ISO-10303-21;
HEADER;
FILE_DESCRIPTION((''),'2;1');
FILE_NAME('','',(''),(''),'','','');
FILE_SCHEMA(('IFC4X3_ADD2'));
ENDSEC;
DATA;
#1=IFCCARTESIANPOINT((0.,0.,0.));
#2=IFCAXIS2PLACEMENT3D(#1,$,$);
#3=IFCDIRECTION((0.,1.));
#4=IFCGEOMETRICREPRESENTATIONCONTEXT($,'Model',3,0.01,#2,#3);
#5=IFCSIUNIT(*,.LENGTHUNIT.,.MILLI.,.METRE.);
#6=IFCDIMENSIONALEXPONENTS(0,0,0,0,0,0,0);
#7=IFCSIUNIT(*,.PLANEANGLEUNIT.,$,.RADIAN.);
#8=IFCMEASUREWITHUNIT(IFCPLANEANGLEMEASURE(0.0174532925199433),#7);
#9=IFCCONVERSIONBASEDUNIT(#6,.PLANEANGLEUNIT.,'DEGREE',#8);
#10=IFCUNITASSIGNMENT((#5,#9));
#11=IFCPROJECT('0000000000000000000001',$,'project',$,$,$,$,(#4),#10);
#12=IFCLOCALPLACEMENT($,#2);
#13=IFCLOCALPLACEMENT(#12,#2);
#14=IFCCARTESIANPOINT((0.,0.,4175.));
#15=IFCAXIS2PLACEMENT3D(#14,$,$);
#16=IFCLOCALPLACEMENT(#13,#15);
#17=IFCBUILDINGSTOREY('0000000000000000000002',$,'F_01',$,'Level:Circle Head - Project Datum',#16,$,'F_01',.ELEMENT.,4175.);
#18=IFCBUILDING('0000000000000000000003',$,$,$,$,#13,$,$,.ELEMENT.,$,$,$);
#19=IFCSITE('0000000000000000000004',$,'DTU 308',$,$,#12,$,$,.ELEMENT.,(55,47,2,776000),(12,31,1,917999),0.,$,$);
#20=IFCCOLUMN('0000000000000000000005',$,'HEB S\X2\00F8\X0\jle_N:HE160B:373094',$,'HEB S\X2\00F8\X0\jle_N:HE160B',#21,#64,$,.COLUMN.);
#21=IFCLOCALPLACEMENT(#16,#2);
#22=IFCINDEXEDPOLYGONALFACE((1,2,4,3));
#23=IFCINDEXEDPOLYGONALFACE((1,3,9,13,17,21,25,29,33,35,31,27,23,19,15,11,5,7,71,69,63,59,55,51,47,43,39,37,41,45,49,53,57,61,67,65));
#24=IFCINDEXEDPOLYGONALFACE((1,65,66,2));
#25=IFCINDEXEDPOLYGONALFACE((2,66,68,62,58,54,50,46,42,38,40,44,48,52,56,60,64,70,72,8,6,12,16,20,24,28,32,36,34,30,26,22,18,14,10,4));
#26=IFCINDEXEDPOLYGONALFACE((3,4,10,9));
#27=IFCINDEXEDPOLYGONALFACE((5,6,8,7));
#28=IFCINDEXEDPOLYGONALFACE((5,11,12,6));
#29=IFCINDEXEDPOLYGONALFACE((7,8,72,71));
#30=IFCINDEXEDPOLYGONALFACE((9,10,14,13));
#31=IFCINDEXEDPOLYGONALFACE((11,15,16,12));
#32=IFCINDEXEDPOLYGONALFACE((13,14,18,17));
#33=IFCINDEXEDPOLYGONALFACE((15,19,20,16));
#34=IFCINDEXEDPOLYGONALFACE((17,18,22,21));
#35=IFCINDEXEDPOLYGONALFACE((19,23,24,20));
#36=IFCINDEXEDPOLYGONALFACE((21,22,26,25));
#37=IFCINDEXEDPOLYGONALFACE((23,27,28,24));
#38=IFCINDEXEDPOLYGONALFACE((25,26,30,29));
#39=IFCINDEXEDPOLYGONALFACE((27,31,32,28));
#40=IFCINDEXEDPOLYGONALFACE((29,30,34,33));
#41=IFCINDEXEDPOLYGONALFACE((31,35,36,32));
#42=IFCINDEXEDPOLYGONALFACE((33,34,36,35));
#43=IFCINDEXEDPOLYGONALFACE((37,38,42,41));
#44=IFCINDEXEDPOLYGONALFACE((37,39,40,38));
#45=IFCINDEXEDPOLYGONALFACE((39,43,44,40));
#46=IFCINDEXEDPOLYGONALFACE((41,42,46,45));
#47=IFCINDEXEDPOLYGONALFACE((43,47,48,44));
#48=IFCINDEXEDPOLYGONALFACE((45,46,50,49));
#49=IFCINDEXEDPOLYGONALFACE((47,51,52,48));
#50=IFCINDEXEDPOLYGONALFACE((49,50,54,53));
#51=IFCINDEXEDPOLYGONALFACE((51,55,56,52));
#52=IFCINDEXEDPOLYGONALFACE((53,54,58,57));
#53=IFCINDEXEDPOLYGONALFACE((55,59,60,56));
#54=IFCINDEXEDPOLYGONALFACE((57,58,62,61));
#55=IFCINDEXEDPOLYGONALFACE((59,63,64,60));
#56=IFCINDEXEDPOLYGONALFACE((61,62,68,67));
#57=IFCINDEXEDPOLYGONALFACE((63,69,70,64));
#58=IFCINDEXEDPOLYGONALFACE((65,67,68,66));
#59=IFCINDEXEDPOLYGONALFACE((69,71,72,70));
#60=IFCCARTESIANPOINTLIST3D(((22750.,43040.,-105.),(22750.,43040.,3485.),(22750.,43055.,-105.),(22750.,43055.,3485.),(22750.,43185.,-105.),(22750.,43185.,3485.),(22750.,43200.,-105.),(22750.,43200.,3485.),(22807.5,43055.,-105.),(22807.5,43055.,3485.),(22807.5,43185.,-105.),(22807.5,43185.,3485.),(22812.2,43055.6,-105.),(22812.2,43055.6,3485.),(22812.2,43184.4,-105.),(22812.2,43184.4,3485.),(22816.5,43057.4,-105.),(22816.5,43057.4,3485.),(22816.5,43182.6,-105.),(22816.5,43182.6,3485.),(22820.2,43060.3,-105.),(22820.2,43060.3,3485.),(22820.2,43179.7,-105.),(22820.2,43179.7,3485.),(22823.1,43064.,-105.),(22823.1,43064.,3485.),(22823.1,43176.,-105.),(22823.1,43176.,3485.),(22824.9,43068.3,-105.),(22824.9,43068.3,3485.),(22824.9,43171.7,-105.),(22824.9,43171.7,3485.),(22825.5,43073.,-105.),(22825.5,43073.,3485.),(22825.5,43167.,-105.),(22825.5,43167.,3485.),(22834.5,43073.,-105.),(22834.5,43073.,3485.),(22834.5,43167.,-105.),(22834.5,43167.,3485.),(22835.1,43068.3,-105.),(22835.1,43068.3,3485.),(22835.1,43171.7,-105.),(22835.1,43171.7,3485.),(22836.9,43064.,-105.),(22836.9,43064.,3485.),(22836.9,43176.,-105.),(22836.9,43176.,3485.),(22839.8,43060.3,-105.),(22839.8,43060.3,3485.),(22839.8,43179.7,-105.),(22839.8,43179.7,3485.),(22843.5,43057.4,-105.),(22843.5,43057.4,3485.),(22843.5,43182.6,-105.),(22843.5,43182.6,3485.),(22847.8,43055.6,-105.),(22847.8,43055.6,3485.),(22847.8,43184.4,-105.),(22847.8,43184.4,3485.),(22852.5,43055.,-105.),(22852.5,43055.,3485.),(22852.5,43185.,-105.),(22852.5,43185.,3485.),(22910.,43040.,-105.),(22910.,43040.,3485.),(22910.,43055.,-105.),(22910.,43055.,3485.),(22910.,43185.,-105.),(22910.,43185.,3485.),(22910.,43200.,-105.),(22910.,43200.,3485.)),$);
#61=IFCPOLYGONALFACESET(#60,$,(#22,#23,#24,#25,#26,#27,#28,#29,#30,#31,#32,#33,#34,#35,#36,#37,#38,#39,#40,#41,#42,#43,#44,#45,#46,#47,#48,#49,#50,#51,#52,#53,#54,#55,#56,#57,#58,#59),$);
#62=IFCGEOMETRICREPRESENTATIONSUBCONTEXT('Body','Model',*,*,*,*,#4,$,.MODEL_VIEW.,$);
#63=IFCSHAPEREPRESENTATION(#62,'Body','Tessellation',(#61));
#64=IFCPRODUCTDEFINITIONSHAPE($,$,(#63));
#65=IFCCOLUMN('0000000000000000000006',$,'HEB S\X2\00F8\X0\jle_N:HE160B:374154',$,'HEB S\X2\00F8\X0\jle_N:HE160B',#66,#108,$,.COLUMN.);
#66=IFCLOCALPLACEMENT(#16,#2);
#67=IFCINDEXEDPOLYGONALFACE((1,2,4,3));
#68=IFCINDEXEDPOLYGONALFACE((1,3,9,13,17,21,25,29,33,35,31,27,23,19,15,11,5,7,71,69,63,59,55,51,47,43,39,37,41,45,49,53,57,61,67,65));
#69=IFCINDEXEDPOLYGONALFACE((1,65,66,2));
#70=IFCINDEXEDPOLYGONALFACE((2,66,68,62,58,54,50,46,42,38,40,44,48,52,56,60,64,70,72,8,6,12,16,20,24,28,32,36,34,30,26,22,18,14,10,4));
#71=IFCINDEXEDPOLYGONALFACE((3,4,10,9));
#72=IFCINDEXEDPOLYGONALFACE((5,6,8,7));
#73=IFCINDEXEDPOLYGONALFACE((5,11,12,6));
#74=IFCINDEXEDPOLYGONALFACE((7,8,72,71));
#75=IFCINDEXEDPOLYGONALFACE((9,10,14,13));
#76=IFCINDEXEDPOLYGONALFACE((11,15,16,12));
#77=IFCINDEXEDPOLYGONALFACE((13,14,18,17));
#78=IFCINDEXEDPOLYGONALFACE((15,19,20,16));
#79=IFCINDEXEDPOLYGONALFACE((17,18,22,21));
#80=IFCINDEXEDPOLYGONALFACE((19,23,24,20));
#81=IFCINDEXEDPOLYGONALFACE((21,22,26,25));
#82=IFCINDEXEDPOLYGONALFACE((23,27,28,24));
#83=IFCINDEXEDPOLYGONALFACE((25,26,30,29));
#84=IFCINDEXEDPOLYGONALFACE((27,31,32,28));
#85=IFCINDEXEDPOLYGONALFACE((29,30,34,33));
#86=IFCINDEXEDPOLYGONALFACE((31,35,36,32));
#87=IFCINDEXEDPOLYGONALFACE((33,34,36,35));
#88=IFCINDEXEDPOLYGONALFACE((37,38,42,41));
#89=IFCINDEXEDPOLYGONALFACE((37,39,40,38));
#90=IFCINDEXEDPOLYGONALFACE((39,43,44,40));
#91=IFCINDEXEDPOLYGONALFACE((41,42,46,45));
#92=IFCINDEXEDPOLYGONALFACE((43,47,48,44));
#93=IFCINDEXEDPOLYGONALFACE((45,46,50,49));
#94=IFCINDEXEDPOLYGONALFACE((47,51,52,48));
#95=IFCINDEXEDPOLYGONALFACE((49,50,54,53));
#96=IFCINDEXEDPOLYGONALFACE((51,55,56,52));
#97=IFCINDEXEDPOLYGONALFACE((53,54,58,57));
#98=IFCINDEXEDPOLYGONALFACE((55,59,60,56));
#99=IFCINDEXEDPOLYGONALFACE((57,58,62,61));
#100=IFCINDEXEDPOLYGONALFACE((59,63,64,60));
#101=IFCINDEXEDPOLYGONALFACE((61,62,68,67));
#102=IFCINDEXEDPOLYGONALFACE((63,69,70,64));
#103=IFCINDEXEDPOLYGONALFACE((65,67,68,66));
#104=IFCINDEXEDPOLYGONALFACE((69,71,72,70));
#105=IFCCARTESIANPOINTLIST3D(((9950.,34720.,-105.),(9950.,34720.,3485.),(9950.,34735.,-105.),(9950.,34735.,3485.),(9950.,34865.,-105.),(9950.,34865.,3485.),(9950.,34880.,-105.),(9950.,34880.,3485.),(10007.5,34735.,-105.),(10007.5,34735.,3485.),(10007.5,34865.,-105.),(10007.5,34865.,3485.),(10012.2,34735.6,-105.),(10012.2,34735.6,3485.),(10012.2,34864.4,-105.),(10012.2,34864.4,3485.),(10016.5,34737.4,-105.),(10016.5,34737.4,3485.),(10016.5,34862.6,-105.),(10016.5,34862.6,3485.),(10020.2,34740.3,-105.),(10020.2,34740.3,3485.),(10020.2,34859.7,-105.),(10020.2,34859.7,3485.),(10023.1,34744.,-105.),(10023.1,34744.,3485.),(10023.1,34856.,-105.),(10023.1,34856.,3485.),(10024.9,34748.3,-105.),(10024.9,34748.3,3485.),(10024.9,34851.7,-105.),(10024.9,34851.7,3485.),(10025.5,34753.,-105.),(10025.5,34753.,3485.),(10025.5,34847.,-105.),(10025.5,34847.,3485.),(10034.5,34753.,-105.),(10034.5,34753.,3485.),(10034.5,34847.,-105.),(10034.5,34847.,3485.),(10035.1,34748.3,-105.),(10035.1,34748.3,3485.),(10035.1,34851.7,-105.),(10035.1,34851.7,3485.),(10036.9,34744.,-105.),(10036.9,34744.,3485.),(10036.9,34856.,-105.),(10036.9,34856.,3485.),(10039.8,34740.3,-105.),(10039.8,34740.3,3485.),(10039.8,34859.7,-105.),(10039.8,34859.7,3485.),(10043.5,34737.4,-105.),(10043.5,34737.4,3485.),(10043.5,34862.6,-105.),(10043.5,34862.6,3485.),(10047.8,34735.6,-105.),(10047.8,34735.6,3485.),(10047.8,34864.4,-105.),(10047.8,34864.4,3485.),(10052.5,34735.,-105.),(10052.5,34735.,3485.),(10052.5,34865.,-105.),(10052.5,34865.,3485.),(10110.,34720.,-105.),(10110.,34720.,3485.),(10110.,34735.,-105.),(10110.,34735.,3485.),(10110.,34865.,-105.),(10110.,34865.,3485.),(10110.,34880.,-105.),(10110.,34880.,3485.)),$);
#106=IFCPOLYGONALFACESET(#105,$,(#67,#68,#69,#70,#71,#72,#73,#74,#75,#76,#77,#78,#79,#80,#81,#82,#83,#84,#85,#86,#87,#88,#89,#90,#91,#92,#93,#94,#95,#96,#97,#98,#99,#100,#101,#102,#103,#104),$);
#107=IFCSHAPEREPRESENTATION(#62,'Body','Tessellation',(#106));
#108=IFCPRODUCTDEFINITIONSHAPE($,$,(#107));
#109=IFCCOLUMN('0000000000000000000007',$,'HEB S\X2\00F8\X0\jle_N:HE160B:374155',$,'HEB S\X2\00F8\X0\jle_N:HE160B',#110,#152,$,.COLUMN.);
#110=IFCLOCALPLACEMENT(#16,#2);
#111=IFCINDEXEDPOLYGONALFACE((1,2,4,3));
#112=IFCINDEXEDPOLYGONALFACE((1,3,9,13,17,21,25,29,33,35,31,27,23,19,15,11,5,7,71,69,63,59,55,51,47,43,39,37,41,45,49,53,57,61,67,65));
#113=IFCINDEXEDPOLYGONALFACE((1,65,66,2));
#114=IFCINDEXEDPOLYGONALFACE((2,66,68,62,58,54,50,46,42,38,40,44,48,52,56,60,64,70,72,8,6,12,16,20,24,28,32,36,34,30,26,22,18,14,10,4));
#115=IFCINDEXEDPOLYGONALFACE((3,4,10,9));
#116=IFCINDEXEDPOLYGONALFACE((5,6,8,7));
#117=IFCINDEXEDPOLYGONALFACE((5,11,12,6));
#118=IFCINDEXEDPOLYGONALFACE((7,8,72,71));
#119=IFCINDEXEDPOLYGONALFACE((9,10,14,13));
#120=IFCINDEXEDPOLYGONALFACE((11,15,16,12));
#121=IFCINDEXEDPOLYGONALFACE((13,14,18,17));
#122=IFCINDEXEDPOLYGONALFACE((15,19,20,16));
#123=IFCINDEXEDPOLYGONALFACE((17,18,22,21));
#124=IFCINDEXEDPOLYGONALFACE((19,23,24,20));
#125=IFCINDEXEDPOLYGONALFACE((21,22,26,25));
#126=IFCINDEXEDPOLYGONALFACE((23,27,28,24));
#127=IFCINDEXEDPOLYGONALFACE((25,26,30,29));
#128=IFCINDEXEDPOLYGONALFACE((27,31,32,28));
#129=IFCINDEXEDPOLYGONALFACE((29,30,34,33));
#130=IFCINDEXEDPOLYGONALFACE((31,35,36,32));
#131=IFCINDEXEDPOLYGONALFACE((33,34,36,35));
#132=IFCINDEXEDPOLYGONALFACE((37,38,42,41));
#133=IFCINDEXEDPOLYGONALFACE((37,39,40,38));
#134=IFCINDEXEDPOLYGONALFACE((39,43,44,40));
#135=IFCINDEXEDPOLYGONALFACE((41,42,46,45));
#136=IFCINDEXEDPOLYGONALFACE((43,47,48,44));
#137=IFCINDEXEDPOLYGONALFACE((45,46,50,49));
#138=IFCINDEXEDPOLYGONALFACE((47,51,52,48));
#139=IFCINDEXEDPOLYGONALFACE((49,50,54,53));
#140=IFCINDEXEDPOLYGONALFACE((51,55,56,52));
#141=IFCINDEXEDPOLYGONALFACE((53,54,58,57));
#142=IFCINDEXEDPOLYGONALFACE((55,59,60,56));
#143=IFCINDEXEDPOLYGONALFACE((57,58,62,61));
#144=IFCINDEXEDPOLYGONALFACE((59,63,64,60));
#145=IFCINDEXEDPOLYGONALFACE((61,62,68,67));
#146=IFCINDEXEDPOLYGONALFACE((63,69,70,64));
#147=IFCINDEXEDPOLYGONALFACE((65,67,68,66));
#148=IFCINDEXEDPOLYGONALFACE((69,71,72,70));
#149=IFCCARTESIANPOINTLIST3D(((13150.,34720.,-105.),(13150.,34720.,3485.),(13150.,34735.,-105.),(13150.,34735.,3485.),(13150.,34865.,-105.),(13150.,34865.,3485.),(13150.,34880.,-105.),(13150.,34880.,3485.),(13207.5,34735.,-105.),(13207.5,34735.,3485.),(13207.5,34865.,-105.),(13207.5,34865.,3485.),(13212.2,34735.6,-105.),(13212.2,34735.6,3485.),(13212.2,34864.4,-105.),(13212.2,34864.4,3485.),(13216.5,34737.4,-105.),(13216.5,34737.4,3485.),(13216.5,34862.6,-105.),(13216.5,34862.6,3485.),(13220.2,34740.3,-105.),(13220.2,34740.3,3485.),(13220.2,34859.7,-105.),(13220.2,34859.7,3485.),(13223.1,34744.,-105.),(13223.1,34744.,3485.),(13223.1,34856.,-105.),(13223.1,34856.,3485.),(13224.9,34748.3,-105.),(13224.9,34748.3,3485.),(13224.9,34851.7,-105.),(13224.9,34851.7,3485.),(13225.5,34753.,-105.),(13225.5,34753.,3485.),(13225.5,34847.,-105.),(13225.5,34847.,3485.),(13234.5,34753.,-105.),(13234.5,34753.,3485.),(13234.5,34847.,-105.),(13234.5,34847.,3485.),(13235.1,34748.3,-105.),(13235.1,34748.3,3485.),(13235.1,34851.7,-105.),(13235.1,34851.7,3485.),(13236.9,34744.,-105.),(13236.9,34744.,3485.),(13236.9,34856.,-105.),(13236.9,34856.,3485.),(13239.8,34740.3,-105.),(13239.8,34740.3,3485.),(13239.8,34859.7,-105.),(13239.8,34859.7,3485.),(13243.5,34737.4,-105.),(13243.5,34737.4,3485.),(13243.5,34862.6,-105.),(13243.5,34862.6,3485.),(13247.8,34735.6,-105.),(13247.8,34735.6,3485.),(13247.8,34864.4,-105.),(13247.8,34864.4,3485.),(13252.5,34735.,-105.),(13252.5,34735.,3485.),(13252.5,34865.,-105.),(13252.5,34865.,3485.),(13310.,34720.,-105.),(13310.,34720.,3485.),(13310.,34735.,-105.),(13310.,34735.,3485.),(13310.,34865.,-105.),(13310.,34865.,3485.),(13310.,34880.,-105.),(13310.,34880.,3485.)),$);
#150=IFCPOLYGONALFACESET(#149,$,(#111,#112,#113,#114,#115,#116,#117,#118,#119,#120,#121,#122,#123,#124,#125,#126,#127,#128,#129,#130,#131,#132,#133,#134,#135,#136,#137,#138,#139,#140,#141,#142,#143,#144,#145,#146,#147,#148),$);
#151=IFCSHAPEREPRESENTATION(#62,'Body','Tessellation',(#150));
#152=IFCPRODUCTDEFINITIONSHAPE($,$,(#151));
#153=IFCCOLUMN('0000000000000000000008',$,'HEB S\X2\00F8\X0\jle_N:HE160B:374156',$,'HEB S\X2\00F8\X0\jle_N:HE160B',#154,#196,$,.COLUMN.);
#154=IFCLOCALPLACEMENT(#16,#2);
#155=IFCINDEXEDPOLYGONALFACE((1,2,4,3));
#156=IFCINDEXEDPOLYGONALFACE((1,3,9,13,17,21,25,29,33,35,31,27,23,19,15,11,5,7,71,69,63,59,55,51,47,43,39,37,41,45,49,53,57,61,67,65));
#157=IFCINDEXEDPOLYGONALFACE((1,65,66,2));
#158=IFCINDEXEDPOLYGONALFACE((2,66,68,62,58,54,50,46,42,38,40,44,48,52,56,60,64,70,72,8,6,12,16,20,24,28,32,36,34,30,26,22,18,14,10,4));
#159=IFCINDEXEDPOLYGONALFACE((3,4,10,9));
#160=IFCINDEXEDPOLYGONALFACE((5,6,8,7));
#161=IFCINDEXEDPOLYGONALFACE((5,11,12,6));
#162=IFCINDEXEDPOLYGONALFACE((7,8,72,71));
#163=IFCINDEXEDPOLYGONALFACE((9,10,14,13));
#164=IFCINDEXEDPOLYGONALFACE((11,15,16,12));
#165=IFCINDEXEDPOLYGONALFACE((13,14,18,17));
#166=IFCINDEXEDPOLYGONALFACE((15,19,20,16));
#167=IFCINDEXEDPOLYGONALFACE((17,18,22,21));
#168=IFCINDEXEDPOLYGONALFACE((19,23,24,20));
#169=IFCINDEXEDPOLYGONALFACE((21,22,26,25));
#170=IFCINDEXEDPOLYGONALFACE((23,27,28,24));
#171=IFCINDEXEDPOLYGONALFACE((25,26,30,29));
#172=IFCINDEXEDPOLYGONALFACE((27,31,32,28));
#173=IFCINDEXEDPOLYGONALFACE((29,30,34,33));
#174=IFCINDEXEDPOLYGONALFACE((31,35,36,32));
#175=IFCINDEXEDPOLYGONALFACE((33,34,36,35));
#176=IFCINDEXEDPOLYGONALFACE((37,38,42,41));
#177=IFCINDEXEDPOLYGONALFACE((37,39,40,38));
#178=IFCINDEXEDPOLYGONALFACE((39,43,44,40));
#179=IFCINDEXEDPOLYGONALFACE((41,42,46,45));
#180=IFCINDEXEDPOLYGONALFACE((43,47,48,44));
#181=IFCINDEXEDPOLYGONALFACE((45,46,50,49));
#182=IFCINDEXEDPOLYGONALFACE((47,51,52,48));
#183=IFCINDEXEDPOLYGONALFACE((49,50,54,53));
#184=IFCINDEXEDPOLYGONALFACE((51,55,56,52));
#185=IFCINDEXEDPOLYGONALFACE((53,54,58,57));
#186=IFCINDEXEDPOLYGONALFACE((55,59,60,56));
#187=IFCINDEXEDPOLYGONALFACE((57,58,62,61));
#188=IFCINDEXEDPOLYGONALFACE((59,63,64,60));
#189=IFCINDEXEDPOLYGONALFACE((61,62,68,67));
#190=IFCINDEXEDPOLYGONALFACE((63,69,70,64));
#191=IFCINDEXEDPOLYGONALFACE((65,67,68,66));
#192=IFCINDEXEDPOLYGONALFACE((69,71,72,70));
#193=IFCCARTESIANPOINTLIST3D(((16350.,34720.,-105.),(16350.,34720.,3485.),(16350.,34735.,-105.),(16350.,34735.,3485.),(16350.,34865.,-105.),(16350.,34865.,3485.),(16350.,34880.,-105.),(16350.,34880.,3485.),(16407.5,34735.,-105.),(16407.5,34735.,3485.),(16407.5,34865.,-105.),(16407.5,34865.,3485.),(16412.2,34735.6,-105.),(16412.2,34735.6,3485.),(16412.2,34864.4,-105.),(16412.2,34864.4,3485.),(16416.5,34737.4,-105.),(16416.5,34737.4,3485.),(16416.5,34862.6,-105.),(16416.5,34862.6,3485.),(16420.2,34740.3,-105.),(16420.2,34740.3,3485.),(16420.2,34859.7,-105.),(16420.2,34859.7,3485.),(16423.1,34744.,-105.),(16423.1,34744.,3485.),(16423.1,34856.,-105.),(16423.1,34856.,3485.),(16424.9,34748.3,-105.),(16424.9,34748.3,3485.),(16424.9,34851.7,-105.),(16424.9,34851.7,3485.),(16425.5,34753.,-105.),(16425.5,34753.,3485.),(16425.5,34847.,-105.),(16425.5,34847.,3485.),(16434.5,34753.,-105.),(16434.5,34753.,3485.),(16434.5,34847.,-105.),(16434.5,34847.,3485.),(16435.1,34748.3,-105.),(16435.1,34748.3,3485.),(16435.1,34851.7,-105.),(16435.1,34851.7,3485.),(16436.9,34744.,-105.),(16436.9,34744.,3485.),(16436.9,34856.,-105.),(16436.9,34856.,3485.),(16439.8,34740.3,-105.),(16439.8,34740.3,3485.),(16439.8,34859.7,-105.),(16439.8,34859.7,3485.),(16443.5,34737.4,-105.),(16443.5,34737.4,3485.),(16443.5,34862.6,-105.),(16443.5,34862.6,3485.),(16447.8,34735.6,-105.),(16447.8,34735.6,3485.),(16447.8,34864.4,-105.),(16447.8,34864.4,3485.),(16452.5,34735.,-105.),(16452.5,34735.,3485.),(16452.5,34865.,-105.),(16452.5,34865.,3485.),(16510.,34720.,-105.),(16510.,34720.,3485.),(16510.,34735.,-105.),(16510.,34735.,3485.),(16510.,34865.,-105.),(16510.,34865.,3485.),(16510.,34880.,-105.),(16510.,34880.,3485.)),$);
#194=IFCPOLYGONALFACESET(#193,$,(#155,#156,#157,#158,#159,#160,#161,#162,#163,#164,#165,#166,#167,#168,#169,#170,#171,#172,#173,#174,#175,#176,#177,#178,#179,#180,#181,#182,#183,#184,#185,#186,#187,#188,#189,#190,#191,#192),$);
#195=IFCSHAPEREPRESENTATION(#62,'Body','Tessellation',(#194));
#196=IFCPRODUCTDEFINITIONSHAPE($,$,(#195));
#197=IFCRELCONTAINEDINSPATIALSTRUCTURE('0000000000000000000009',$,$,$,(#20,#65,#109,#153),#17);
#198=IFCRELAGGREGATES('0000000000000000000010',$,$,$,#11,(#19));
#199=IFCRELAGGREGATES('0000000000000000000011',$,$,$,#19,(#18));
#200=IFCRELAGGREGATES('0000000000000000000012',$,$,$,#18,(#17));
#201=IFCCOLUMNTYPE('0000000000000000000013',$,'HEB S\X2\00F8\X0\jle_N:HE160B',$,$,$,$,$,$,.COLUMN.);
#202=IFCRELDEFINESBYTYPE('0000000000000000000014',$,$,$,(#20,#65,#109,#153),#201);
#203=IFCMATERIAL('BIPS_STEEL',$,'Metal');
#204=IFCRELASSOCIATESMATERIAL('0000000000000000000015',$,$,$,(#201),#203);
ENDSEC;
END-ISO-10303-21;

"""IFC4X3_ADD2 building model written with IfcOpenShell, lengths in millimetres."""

from ifc_helpers import new_model, entity, si_unit, converted_unit, direction, frame, frame_2d, origin, place, context, subcontext, project, spatial, i_section, extrude, source, transform, mapped, material, material_profile, profile_set, type_object, element, save


model = new_model("IFC4X3_ADD2")

# Units and contexts
model_context = context("Model", 3, precision=0.01, world=origin(), true_north=direction((0.0, 1.0)))
body_context = subcontext(model_context, "Body", "Model", "MODEL_VIEW")
ifc_project = project(units=[si_unit("LENGTHUNIT", "METRE", prefix="MILLI"), converted_unit("PLANEANGLEUNIT", "DEGREE", entity("IfcPlaneAngleMeasure", 0.0174532925199433), si_unit("PLANEANGLEUNIT", "RADIAN"), dimensions=[0, 0, 0, 0, 0, 0, 0])], contexts=[model_context])

# Site, building, storey
site_placement = place(None, origin())
site = spatial("IfcSite", under=ifc_project, at=site_placement, Name="DTU 308", CompositionType="ELEMENT", RefLatitude=(55, 47, 2, 776000), RefLongitude=(12, 31, 1, 917999), RefElevation=0.0)
building_placement = place(site_placement, origin())
building = spatial("IfcBuilding", under=site, at=building_placement, CompositionType="ELEMENT")
storey_placement = place(building_placement, frame((0.0, 0.0, 4175.0)))
storey = spatial("IfcBuildingStorey", under=building, at=storey_placement, Name="F_01", ObjectType="Level:Circle Head - Project Datum", LongName="F_01", CompositionType="ELEMENT", Elevation=4175.0)

# Columns
ifc_material_1 = material(Name="BIPS_STEEL", Category="Metal")
ifc_material_profile_1 = material_profile(ifc_material_1, i_section(OverallWidth=160.0, OverallDepth=160.0, WebThickness=9.0, FlangeThickness=15.0, FilletRadius=18.0, at=frame_2d((0.0, 0.0), x_axis=(1.0, 0.0))), Name="HE160B")
ifc_profile_set_1 = profile_set([ifc_material_profile_1], Name="HE160B")
column_type_1 = type_object("IfcColumnType", Name="HEB Søjle_N:HE160B", PredefinedType="COLUMN", material=ifc_profile_set_1)
shared_shape_1 = source(origin(), body_context, "Body", "SweptSolid", [
    extrude(i_section(OverallWidth=160.0, OverallDepth=160.0, WebThickness=9.0, FlangeThickness=15.0, FilletRadius=18.0, at=frame_2d((0.0, 0.0), x_axis=(1.0, 0.0))), frame((0.0, 0.0, 4070.0), z_axis=(0.0, 0.0, 1.0), x_axis=(-1.0, 0.0, 0.0)), (0.0, 0.0, 1.0), 3590.0),
])
for number, where, name in (
    (1, (22830.0, 43120.0, -4175.0), "HEB Søjle_N:HE160B:373094"),
    (2, (10030.0, 34800.0, -4175.0), "HEB Søjle_N:HE160B:374154"),
    (3, (13230.0, 34800.0, -4175.0), "HEB Søjle_N:HE160B:374155"),
    (4, (16430.0, 34800.0, -4175.0), "HEB Søjle_N:HE160B:374156"),
):
    element("IfcColumn", number, at=place(storey_placement, frame(where)), inside=storey, type_object=column_type_1, Name=name, ObjectType="HEB Søjle_N:HE160B", PredefinedType="COLUMN", context=body_context, shape_type="MappedRepresentation", body=[
        mapped(shared_shape_1, transform((0.0, 0.0, 0.0), scale=1.0)),
    ])

save(model, "model.ifc")
